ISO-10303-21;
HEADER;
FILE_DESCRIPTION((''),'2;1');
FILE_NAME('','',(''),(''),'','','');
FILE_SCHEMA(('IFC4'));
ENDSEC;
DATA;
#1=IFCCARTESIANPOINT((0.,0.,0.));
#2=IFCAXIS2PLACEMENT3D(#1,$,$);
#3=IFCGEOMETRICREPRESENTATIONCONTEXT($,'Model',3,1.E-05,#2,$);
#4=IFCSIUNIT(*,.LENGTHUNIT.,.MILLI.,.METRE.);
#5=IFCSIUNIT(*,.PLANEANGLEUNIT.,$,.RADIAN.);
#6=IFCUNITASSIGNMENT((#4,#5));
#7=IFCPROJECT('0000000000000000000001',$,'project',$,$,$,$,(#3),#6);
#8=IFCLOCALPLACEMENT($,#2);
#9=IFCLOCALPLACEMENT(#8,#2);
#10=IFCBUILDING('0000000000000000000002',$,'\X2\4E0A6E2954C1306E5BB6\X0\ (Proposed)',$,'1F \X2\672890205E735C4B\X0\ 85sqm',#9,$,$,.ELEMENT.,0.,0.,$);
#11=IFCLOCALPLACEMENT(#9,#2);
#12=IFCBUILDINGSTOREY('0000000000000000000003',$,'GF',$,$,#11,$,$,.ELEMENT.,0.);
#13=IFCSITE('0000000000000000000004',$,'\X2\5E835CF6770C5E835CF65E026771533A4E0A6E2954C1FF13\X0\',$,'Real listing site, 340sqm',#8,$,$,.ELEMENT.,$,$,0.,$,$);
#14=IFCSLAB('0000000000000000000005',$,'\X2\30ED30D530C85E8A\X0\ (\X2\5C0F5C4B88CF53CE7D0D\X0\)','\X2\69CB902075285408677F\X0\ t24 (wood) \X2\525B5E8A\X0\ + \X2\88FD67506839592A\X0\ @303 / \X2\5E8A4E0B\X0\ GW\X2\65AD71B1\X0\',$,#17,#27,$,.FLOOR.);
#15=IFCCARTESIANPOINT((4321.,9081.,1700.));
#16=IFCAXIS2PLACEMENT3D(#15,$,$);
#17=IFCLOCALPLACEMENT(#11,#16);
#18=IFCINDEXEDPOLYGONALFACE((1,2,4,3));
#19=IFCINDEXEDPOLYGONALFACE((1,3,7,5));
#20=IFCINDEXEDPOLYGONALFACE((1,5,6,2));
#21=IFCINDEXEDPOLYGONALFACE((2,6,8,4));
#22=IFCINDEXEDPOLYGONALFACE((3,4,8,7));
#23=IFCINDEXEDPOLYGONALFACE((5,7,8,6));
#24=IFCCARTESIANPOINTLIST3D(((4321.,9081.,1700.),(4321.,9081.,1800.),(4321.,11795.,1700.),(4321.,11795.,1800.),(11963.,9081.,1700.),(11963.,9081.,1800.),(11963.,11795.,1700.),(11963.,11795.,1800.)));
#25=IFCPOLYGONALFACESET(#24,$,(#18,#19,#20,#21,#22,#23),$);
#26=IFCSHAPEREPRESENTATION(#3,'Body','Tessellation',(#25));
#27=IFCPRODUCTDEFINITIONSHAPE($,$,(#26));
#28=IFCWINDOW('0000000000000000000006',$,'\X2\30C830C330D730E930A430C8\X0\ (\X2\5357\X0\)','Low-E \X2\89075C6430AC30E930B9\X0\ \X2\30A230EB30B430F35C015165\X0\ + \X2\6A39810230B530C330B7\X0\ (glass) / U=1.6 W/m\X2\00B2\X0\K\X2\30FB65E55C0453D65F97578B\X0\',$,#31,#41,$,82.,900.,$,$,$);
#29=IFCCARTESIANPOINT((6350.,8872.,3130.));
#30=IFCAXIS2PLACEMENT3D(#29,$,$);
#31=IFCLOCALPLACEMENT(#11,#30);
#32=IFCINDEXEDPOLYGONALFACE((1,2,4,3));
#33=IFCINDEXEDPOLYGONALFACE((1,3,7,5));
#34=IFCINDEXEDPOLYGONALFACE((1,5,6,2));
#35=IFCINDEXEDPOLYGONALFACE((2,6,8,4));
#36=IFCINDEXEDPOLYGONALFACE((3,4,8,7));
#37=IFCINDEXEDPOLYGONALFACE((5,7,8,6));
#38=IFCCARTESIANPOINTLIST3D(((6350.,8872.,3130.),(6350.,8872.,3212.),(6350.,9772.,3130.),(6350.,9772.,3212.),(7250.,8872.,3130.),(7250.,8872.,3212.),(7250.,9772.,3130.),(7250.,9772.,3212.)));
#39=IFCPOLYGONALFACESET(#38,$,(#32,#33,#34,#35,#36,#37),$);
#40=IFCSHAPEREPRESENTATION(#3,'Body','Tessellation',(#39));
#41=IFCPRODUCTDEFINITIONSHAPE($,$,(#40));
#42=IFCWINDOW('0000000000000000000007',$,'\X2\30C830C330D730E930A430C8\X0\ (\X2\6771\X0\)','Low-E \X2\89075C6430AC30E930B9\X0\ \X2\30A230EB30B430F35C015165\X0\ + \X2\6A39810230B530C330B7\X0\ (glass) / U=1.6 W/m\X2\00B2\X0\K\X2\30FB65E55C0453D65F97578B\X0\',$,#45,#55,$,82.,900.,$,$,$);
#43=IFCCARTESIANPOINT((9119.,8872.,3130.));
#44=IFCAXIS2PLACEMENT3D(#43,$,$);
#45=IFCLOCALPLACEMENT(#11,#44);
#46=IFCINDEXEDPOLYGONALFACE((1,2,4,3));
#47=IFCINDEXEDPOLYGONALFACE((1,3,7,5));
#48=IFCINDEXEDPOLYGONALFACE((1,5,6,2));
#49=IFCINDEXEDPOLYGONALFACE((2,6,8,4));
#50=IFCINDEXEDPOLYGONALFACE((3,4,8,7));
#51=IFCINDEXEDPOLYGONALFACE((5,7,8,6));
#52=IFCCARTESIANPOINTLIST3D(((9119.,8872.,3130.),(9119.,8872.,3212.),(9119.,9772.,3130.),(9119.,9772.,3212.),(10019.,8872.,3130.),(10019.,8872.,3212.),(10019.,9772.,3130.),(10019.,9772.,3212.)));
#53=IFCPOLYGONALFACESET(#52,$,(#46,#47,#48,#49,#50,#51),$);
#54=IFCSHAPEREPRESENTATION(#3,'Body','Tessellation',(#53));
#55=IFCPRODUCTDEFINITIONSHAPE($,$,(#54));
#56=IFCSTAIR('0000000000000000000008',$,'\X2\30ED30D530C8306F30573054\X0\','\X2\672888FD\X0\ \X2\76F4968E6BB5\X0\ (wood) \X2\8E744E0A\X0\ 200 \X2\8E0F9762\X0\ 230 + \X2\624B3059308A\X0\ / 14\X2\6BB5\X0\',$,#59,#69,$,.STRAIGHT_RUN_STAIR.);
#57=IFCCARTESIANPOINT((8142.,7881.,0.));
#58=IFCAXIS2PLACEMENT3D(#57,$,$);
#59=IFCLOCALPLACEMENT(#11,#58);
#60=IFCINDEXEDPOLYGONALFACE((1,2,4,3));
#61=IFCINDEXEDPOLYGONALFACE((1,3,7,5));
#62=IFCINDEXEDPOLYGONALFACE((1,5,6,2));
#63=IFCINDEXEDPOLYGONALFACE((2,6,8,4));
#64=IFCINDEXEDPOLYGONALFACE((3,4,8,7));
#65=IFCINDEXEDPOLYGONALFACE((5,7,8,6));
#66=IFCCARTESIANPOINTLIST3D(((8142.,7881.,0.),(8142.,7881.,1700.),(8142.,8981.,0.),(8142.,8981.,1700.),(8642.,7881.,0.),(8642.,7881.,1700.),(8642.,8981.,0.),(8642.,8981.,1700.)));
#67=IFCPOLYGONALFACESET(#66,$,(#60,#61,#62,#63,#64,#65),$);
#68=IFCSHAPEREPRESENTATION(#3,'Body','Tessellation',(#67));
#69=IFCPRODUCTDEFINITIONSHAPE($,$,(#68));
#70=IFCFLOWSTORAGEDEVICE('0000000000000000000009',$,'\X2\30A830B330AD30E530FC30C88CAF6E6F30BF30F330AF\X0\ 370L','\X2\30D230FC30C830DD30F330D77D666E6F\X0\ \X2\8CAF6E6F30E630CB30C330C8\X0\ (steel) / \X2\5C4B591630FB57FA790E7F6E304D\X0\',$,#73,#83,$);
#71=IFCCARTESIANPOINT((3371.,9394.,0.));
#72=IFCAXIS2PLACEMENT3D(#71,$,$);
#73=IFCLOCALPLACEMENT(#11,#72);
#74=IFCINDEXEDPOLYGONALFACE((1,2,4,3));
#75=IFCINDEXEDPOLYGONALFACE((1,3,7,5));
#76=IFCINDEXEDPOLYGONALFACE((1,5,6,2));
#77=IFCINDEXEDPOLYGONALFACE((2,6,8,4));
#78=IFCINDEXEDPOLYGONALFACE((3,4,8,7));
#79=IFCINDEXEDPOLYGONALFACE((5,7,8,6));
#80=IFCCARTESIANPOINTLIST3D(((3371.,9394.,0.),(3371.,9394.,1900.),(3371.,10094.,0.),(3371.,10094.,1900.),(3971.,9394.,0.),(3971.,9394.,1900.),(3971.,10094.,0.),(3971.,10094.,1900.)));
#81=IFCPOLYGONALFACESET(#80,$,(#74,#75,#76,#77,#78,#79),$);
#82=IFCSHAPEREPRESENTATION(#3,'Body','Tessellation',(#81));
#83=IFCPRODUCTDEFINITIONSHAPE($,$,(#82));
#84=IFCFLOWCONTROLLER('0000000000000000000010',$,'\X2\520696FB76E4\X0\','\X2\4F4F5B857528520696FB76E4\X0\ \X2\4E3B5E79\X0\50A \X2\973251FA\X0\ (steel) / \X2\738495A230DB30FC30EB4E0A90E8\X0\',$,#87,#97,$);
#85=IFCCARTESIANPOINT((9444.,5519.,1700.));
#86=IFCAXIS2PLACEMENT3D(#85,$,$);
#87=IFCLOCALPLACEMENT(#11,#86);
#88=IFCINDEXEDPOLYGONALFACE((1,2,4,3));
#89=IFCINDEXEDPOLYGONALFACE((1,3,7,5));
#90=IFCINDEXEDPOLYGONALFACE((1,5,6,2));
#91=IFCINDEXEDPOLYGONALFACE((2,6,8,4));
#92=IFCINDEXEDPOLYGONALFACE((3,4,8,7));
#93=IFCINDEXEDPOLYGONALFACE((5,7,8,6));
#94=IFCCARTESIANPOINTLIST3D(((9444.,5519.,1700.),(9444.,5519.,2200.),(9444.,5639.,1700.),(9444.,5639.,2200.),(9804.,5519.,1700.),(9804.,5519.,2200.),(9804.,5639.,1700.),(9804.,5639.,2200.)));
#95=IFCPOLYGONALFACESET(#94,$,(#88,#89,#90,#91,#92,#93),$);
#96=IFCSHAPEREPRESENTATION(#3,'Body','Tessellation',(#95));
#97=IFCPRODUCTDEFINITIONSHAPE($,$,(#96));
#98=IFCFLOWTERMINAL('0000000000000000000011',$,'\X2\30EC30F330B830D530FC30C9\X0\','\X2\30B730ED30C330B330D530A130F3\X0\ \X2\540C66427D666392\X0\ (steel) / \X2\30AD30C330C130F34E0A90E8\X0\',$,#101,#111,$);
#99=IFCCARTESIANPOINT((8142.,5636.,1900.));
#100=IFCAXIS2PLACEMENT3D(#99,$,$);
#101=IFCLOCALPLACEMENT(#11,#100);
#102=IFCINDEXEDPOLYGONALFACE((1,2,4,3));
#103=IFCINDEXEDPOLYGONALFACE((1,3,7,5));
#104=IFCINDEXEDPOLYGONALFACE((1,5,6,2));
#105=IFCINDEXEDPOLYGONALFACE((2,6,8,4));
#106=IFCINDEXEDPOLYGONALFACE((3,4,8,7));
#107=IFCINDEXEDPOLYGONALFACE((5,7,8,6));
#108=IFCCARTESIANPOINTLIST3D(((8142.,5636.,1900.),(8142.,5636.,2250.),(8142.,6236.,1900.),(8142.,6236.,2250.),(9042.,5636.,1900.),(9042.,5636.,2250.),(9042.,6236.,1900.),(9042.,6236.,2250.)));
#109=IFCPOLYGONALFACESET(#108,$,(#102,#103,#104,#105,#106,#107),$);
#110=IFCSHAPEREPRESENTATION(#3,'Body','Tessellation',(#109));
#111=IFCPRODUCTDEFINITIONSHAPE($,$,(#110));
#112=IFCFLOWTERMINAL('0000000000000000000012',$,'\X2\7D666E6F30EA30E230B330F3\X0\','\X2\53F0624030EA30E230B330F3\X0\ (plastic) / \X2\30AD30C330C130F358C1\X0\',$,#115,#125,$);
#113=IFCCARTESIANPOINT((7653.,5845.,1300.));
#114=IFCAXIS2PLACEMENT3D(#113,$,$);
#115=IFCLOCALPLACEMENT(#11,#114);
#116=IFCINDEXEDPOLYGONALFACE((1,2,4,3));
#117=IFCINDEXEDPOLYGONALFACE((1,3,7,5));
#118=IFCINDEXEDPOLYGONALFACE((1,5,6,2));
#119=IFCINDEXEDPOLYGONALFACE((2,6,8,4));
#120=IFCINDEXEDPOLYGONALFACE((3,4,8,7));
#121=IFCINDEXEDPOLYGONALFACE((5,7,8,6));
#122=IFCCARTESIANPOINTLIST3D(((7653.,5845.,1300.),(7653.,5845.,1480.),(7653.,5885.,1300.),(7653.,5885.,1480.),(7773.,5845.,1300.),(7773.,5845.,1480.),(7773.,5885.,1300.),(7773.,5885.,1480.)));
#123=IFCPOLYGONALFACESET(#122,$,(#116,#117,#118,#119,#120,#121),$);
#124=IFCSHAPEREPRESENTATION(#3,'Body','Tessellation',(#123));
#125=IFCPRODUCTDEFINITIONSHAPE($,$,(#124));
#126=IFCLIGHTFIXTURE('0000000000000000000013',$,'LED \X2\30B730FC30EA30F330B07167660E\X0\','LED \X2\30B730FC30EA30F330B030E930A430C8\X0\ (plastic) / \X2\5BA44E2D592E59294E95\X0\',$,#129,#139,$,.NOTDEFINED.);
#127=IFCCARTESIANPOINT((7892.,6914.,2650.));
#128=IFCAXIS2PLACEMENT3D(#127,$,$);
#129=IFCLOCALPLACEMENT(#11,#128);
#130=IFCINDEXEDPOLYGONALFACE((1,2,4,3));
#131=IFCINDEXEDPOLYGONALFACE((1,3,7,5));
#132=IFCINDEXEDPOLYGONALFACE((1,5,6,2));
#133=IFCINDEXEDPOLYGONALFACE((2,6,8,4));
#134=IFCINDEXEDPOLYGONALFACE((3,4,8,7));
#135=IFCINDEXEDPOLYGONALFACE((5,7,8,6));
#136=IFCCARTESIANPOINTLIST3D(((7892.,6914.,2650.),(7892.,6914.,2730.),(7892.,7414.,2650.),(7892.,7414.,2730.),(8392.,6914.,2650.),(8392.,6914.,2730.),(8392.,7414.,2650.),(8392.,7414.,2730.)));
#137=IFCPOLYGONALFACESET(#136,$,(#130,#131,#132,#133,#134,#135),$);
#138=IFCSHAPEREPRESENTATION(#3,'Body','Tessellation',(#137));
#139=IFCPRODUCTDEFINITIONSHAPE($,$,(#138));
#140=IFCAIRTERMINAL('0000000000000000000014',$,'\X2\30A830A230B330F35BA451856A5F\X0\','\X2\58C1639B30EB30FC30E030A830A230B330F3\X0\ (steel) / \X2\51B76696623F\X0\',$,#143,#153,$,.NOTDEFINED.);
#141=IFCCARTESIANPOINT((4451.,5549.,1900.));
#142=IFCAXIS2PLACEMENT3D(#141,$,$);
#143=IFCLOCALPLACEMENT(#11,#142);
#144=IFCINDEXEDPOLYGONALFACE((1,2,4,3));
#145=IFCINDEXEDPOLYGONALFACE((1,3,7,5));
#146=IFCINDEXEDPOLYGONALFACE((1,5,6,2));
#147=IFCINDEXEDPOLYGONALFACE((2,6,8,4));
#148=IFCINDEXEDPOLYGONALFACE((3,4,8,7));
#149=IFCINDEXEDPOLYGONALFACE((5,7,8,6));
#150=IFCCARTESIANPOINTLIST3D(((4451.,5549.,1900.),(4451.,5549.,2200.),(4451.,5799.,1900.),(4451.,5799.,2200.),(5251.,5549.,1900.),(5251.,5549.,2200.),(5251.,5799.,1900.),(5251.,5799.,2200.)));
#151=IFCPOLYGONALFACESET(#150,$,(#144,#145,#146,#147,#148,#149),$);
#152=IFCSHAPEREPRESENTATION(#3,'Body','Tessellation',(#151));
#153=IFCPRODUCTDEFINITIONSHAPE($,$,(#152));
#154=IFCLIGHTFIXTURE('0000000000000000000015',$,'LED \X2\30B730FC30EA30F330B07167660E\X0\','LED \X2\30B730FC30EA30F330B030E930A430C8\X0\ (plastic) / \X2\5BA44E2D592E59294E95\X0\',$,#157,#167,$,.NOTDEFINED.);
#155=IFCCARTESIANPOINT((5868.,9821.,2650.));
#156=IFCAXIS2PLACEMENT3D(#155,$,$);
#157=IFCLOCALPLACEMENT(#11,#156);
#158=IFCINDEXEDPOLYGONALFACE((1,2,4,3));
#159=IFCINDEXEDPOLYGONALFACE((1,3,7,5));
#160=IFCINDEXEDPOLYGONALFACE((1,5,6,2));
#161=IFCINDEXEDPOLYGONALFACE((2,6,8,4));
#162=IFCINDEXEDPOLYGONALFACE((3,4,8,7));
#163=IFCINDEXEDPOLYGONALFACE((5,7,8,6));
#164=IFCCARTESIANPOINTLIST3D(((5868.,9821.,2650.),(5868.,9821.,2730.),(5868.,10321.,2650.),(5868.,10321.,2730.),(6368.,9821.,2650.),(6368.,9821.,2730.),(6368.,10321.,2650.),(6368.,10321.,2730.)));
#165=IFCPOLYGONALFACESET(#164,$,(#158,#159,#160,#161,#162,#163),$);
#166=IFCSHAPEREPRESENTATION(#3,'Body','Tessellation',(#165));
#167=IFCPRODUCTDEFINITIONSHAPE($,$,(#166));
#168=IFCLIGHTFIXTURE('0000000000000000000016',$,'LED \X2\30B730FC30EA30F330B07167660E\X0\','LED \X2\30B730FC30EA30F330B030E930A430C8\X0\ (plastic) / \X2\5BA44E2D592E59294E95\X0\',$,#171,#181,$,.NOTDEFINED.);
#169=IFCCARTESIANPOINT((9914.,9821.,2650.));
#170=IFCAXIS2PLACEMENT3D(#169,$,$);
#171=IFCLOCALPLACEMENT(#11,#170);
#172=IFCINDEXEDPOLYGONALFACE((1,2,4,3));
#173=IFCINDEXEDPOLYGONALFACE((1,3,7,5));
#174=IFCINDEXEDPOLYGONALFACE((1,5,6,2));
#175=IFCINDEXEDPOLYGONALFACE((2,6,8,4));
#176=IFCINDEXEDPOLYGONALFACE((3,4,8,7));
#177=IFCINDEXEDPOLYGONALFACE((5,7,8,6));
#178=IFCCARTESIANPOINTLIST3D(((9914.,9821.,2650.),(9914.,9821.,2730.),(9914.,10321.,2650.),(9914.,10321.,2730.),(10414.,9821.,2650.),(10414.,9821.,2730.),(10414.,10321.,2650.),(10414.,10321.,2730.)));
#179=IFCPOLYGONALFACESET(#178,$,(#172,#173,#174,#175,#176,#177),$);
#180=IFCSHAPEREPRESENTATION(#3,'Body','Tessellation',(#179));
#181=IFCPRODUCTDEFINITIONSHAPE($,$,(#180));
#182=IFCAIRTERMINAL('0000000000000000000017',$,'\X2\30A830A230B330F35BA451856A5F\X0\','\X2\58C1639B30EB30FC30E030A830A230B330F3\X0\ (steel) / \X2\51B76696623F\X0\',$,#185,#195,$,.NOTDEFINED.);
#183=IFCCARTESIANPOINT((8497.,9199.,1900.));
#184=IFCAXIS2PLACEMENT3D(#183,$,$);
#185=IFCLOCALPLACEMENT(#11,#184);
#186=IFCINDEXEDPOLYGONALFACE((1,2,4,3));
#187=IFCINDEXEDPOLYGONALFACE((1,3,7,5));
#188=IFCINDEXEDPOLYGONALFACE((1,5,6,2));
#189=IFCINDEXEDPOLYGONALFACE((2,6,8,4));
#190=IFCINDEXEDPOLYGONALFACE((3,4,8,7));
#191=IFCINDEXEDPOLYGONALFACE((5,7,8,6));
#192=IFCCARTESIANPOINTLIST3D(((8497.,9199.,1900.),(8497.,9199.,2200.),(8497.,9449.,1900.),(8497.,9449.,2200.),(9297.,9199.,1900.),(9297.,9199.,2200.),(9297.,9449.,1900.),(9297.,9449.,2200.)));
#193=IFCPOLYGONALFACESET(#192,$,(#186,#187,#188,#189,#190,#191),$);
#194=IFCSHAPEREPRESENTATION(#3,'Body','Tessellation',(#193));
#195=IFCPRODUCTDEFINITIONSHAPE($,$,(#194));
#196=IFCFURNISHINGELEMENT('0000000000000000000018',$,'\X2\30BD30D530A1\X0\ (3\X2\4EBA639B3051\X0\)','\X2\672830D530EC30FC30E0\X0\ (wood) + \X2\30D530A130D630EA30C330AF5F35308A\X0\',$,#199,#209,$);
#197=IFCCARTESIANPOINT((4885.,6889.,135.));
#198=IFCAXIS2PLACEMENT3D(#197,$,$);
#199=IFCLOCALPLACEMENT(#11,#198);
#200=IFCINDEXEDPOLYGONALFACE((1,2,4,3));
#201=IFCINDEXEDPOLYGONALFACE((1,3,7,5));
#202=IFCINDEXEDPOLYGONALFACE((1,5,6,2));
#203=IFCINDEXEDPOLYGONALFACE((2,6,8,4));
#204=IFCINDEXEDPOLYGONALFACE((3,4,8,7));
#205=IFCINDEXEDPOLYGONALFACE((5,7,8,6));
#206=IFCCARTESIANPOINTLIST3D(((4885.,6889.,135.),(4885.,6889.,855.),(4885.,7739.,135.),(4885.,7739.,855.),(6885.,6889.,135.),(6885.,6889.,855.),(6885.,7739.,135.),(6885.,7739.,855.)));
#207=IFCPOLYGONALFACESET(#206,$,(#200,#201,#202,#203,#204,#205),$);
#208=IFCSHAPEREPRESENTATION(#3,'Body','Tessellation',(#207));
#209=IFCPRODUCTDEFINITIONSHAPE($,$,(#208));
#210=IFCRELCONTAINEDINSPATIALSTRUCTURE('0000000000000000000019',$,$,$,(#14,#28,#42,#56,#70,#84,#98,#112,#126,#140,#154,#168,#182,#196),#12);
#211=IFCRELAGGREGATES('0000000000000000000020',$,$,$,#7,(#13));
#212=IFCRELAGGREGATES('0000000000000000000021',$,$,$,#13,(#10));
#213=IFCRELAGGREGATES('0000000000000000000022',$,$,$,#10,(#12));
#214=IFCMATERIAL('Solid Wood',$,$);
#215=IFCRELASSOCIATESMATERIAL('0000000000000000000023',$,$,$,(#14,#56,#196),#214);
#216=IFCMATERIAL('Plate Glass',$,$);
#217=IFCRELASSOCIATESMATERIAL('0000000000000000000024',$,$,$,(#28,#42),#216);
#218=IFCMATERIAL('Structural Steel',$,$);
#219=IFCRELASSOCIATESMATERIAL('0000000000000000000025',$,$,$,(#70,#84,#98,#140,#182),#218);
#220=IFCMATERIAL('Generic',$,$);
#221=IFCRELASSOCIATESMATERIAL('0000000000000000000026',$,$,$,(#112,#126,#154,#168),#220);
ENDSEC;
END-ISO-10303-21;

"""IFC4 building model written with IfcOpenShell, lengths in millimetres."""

from ifc_helpers import new_model, si_unit, frame, frame_2d, origin, place, context, project, spatial, rectangle, extrude, material, element, save


model = new_model("IFC4")

# Units and contexts
model_context = context("Model", 3, precision=1e-05, world=origin())
ifc_project = project(units=[si_unit("LENGTHUNIT", "METRE", prefix="MILLI"), si_unit("PLANEANGLEUNIT", "RADIAN")], contexts=[model_context])

# Site, building, storey
site_placement = place(None, origin())
site = spatial("IfcSite", under=ifc_project, at=site_placement, Name="広島県広島市東区上温品３", ObjectType="Real listing site, 340sqm", CompositionType="ELEMENT", RefElevation=0.0)
building_placement = place(site_placement, origin())
building = spatial("IfcBuilding", under=site, at=building_placement, Name="上温品の家 (Proposed)", ObjectType="1F 木造平屋 85sqm", CompositionType="ELEMENT", ElevationOfRefHeight=0.0, ElevationOfTerrain=0.0)
storey_placement = place(building_placement, origin())
storey = spatial("IfcBuildingStorey", under=building, at=storey_placement, Name="GF", CompositionType="ELEMENT", Elevation=0.0)

# Shared definitions
ifc_material_1 = material(Name="Solid Wood")

# Slab
slab_placement = place(storey_placement, frame((4321.0, 9081.0, 1700.0)))
element("IfcSlab", 1, at=slab_placement, inside=storey, material=ifc_material_1, Name="ロフト床 (小屋裏収納)", Description="構造用合板 t24 (wood) 剛床 + 製材根太 @303 / 床下 GW断熱", PredefinedType="FLOOR", context=model_context, shape_type="SweptSolid", body=[
    extrude(rectangle(XDim=7642.0, YDim=2714.0, at=frame_2d((3821.0, 1357.0))), frame((4321.0, 9081.0, 1700.0)), (0.0, 0.0, 1.0), 100.0),
])

# Windows
ifc_material_2 = material(Name="Plate Glass")
window_1_placement = place(storey_placement, frame((6350.0, 8872.0, 3130.0)))
element("IfcWindow", 2, at=window_1_placement, inside=storey, material=ifc_material_2, Name="トップライト (南)", Description="Low-E 複層ガラス アルゴン封入 + 樹脂サッシ (glass) / U=1.6 W/m²K・日射取得型", OverallHeight=82.0, OverallWidth=900.0, context=model_context, shape_type="SweptSolid", body=[
    extrude(rectangle(XDim=900.0, YDim=900.0, at=frame_2d((450.0, 450.0))), frame((6350.0, 8872.0, 3130.0)), (0.0, 0.0, 1.0), 82.0),
])
window_2_placement = place(storey_placement, frame((9119.0, 8872.0, 3130.0)))
element("IfcWindow", 3, at=window_2_placement, inside=storey, material=ifc_material_2, Name="トップライト (東)", Description="Low-E 複層ガラス アルゴン封入 + 樹脂サッシ (glass) / U=1.6 W/m²K・日射取得型", OverallHeight=82.0, OverallWidth=900.0, context=model_context, shape_type="SweptSolid", body=[
    extrude(rectangle(XDim=900.0, YDim=900.0, at=frame_2d((450.0, 450.0))), frame((9119.0, 8872.0, 3130.0)), (0.0, 0.0, 1.0), 82.0),
])

# Stair
stair_placement = place(storey_placement, frame((8142.0, 7881.0, 0.0)))
element("IfcStair", 4, at=stair_placement, inside=storey, material=ifc_material_1, Name="ロフトはしご", Description="木製 直階段 (wood) 蹴上 200 踏面 230 + 手すり / 14段", PredefinedType="STRAIGHT_RUN_STAIR", context=model_context, shape_type="SweptSolid", body=[
    extrude(rectangle(XDim=500.0, YDim=1100.0, at=frame_2d((250.0, 550.0))), frame((8142.0, 7881.0, 0.0)), (0.0, 0.0, 1.0), 1700.0),
])

# Flow storage device
ifc_material_3 = material(Name="Structural Steel")
flow_storage_device_placement = place(storey_placement, frame((3371.0, 9394.0, 0.0)))
element("IfcFlowStorageDevice", 5, at=flow_storage_device_placement, inside=storey, material=ifc_material_3, Name="エコキュート貯湯タンク 370L", Description="ヒートポンプ給湯 貯湯ユニット (steel) / 屋外・基礎置き", context=model_context, shape_type="SweptSolid", body=[
    extrude(rectangle(XDim=600.0, YDim=700.0, at=frame_2d((300.0, 350.0))), frame((3371.0, 9394.0, 0.0)), (0.0, 0.0, 1.0), 1900.0),
])

# Flow controller
flow_controller_placement = place(storey_placement, frame((9444.0, 5519.0, 1700.0)))
element("IfcFlowController", 6, at=flow_controller_placement, inside=storey, material=ifc_material_3, Name="分電盤", Description="住宅用分電盤 主幹50A 露出 (steel) / 玄関ホール上部", context=model_context, shape_type="SweptSolid", body=[
    extrude(rectangle(XDim=360.0, YDim=120.0, at=frame_2d((180.0, 60.0))), frame((9444.0, 5519.0, 1700.0)), (0.0, 0.0, 1.0), 500.0),
])

# Flow terminals
flow_terminal_1_placement = place(storey_placement, frame((8142.0, 5636.0, 1900.0)))
element("IfcFlowTerminal", 7, at=flow_terminal_1_placement, inside=storey, material=ifc_material_3, Name="レンジフード", Description="シロッコファン 同時給排 (steel) / キッチン上部", context=model_context, shape_type="SweptSolid", body=[
    extrude(rectangle(XDim=900.0, YDim=600.0, at=frame_2d((450.0, 300.0))), frame((8142.0, 5636.0, 1900.0)), (0.0, 0.0, 1.0), 350.0),
])
ifc_material_4 = material(Name="Generic")
flow_terminal_2_placement = place(storey_placement, frame((7653.0, 5845.0, 1300.0)))
element("IfcFlowTerminal", 8, at=flow_terminal_2_placement, inside=storey, material=ifc_material_4, Name="給湯リモコン", Description="台所リモコン (plastic) / キッチン壁", context=model_context, shape_type="SweptSolid", body=[
    extrude(rectangle(XDim=120.0, YDim=40.0, at=frame_2d((60.0, 20.0))), frame((7653.0, 5845.0, 1300.0)), (0.0, 0.0, 1.0), 180.0),
])

# Light fixture
light_fixture_1_placement = place(storey_placement, frame((7892.0, 6914.0, 2650.0)))
element("IfcLightFixture", 9, at=light_fixture_1_placement, inside=storey, material=ifc_material_4, Name="LED シーリング照明", Description="LED シーリングライト (plastic) / 室中央天井", PredefinedType="NOTDEFINED", context=model_context, shape_type="SweptSolid", body=[
    extrude(rectangle(XDim=500.0, YDim=500.0, at=frame_2d((250.0, 250.0))), frame((7892.0, 6914.0, 2650.0)), (0.0, 0.0, 1.0), 80.0),
])

# Air terminal
air_terminal_1_placement = place(storey_placement, frame((4451.0, 5549.0, 1900.0)))
element("IfcAirTerminal", 10, at=air_terminal_1_placement, inside=storey, material=ifc_material_3, Name="エアコン室内機", Description="壁掛ルームエアコン (steel) / 冷暖房", PredefinedType="NOTDEFINED", context=model_context, shape_type="SweptSolid", body=[
    extrude(rectangle(XDim=800.0, YDim=250.0, at=frame_2d((400.0, 125.0))), frame((4451.0, 5549.0, 1900.0)), (0.0, 0.0, 1.0), 300.0),
])

# Light fixtures
light_fixture_2_placement = place(storey_placement, frame((5868.0, 9821.0, 2650.0)))
element("IfcLightFixture", 11, at=light_fixture_2_placement, inside=storey, material=ifc_material_4, Name="LED シーリング照明", Description="LED シーリングライト (plastic) / 室中央天井", PredefinedType="NOTDEFINED", context=model_context, shape_type="SweptSolid", body=[
    extrude(rectangle(XDim=500.0, YDim=500.0, at=frame_2d((250.0, 250.0))), frame((5868.0, 9821.0, 2650.0)), (0.0, 0.0, 1.0), 80.0),
])
light_fixture_3_placement = place(storey_placement, frame((9914.0, 9821.0, 2650.0)))
element("IfcLightFixture", 12, at=light_fixture_3_placement, inside=storey, material=ifc_material_4, Name="LED シーリング照明", Description="LED シーリングライト (plastic) / 室中央天井", PredefinedType="NOTDEFINED", context=model_context, shape_type="SweptSolid", body=[
    extrude(rectangle(XDim=500.0, YDim=500.0, at=frame_2d((250.0, 250.0))), frame((9914.0, 9821.0, 2650.0)), (0.0, 0.0, 1.0), 80.0),
])

# Air terminal
air_terminal_2_placement = place(storey_placement, frame((8497.0, 9199.0, 1900.0)))
element("IfcAirTerminal", 13, at=air_terminal_2_placement, inside=storey, material=ifc_material_3, Name="エアコン室内機", Description="壁掛ルームエアコン (steel) / 冷暖房", PredefinedType="NOTDEFINED", context=model_context, shape_type="SweptSolid", body=[
    extrude(rectangle(XDim=800.0, YDim=250.0, at=frame_2d((400.0, 125.0))), frame((8497.0, 9199.0, 1900.0)), (0.0, 0.0, 1.0), 300.0),
])

# Furnishing element
furnishing_1_placement = place(storey_placement, frame((4885.0, 6889.0, 135.0)))
element("IfcFurnishingElement", 14, at=furnishing_1_placement, inside=storey, material=ifc_material_1, Name="ソファ (3人掛け)", Description="木フレーム (wood) + ファブリック張り", context=model_context, shape_type="SweptSolid", body=[
    extrude(rectangle(XDim=2000.0, YDim=850.0, at=frame_2d((1000.0, 425.0))), frame((4885.0, 6889.0, 135.0)), (0.0, 0.0, 1.0), 720.0),
])

save(model, "model.ifc")
